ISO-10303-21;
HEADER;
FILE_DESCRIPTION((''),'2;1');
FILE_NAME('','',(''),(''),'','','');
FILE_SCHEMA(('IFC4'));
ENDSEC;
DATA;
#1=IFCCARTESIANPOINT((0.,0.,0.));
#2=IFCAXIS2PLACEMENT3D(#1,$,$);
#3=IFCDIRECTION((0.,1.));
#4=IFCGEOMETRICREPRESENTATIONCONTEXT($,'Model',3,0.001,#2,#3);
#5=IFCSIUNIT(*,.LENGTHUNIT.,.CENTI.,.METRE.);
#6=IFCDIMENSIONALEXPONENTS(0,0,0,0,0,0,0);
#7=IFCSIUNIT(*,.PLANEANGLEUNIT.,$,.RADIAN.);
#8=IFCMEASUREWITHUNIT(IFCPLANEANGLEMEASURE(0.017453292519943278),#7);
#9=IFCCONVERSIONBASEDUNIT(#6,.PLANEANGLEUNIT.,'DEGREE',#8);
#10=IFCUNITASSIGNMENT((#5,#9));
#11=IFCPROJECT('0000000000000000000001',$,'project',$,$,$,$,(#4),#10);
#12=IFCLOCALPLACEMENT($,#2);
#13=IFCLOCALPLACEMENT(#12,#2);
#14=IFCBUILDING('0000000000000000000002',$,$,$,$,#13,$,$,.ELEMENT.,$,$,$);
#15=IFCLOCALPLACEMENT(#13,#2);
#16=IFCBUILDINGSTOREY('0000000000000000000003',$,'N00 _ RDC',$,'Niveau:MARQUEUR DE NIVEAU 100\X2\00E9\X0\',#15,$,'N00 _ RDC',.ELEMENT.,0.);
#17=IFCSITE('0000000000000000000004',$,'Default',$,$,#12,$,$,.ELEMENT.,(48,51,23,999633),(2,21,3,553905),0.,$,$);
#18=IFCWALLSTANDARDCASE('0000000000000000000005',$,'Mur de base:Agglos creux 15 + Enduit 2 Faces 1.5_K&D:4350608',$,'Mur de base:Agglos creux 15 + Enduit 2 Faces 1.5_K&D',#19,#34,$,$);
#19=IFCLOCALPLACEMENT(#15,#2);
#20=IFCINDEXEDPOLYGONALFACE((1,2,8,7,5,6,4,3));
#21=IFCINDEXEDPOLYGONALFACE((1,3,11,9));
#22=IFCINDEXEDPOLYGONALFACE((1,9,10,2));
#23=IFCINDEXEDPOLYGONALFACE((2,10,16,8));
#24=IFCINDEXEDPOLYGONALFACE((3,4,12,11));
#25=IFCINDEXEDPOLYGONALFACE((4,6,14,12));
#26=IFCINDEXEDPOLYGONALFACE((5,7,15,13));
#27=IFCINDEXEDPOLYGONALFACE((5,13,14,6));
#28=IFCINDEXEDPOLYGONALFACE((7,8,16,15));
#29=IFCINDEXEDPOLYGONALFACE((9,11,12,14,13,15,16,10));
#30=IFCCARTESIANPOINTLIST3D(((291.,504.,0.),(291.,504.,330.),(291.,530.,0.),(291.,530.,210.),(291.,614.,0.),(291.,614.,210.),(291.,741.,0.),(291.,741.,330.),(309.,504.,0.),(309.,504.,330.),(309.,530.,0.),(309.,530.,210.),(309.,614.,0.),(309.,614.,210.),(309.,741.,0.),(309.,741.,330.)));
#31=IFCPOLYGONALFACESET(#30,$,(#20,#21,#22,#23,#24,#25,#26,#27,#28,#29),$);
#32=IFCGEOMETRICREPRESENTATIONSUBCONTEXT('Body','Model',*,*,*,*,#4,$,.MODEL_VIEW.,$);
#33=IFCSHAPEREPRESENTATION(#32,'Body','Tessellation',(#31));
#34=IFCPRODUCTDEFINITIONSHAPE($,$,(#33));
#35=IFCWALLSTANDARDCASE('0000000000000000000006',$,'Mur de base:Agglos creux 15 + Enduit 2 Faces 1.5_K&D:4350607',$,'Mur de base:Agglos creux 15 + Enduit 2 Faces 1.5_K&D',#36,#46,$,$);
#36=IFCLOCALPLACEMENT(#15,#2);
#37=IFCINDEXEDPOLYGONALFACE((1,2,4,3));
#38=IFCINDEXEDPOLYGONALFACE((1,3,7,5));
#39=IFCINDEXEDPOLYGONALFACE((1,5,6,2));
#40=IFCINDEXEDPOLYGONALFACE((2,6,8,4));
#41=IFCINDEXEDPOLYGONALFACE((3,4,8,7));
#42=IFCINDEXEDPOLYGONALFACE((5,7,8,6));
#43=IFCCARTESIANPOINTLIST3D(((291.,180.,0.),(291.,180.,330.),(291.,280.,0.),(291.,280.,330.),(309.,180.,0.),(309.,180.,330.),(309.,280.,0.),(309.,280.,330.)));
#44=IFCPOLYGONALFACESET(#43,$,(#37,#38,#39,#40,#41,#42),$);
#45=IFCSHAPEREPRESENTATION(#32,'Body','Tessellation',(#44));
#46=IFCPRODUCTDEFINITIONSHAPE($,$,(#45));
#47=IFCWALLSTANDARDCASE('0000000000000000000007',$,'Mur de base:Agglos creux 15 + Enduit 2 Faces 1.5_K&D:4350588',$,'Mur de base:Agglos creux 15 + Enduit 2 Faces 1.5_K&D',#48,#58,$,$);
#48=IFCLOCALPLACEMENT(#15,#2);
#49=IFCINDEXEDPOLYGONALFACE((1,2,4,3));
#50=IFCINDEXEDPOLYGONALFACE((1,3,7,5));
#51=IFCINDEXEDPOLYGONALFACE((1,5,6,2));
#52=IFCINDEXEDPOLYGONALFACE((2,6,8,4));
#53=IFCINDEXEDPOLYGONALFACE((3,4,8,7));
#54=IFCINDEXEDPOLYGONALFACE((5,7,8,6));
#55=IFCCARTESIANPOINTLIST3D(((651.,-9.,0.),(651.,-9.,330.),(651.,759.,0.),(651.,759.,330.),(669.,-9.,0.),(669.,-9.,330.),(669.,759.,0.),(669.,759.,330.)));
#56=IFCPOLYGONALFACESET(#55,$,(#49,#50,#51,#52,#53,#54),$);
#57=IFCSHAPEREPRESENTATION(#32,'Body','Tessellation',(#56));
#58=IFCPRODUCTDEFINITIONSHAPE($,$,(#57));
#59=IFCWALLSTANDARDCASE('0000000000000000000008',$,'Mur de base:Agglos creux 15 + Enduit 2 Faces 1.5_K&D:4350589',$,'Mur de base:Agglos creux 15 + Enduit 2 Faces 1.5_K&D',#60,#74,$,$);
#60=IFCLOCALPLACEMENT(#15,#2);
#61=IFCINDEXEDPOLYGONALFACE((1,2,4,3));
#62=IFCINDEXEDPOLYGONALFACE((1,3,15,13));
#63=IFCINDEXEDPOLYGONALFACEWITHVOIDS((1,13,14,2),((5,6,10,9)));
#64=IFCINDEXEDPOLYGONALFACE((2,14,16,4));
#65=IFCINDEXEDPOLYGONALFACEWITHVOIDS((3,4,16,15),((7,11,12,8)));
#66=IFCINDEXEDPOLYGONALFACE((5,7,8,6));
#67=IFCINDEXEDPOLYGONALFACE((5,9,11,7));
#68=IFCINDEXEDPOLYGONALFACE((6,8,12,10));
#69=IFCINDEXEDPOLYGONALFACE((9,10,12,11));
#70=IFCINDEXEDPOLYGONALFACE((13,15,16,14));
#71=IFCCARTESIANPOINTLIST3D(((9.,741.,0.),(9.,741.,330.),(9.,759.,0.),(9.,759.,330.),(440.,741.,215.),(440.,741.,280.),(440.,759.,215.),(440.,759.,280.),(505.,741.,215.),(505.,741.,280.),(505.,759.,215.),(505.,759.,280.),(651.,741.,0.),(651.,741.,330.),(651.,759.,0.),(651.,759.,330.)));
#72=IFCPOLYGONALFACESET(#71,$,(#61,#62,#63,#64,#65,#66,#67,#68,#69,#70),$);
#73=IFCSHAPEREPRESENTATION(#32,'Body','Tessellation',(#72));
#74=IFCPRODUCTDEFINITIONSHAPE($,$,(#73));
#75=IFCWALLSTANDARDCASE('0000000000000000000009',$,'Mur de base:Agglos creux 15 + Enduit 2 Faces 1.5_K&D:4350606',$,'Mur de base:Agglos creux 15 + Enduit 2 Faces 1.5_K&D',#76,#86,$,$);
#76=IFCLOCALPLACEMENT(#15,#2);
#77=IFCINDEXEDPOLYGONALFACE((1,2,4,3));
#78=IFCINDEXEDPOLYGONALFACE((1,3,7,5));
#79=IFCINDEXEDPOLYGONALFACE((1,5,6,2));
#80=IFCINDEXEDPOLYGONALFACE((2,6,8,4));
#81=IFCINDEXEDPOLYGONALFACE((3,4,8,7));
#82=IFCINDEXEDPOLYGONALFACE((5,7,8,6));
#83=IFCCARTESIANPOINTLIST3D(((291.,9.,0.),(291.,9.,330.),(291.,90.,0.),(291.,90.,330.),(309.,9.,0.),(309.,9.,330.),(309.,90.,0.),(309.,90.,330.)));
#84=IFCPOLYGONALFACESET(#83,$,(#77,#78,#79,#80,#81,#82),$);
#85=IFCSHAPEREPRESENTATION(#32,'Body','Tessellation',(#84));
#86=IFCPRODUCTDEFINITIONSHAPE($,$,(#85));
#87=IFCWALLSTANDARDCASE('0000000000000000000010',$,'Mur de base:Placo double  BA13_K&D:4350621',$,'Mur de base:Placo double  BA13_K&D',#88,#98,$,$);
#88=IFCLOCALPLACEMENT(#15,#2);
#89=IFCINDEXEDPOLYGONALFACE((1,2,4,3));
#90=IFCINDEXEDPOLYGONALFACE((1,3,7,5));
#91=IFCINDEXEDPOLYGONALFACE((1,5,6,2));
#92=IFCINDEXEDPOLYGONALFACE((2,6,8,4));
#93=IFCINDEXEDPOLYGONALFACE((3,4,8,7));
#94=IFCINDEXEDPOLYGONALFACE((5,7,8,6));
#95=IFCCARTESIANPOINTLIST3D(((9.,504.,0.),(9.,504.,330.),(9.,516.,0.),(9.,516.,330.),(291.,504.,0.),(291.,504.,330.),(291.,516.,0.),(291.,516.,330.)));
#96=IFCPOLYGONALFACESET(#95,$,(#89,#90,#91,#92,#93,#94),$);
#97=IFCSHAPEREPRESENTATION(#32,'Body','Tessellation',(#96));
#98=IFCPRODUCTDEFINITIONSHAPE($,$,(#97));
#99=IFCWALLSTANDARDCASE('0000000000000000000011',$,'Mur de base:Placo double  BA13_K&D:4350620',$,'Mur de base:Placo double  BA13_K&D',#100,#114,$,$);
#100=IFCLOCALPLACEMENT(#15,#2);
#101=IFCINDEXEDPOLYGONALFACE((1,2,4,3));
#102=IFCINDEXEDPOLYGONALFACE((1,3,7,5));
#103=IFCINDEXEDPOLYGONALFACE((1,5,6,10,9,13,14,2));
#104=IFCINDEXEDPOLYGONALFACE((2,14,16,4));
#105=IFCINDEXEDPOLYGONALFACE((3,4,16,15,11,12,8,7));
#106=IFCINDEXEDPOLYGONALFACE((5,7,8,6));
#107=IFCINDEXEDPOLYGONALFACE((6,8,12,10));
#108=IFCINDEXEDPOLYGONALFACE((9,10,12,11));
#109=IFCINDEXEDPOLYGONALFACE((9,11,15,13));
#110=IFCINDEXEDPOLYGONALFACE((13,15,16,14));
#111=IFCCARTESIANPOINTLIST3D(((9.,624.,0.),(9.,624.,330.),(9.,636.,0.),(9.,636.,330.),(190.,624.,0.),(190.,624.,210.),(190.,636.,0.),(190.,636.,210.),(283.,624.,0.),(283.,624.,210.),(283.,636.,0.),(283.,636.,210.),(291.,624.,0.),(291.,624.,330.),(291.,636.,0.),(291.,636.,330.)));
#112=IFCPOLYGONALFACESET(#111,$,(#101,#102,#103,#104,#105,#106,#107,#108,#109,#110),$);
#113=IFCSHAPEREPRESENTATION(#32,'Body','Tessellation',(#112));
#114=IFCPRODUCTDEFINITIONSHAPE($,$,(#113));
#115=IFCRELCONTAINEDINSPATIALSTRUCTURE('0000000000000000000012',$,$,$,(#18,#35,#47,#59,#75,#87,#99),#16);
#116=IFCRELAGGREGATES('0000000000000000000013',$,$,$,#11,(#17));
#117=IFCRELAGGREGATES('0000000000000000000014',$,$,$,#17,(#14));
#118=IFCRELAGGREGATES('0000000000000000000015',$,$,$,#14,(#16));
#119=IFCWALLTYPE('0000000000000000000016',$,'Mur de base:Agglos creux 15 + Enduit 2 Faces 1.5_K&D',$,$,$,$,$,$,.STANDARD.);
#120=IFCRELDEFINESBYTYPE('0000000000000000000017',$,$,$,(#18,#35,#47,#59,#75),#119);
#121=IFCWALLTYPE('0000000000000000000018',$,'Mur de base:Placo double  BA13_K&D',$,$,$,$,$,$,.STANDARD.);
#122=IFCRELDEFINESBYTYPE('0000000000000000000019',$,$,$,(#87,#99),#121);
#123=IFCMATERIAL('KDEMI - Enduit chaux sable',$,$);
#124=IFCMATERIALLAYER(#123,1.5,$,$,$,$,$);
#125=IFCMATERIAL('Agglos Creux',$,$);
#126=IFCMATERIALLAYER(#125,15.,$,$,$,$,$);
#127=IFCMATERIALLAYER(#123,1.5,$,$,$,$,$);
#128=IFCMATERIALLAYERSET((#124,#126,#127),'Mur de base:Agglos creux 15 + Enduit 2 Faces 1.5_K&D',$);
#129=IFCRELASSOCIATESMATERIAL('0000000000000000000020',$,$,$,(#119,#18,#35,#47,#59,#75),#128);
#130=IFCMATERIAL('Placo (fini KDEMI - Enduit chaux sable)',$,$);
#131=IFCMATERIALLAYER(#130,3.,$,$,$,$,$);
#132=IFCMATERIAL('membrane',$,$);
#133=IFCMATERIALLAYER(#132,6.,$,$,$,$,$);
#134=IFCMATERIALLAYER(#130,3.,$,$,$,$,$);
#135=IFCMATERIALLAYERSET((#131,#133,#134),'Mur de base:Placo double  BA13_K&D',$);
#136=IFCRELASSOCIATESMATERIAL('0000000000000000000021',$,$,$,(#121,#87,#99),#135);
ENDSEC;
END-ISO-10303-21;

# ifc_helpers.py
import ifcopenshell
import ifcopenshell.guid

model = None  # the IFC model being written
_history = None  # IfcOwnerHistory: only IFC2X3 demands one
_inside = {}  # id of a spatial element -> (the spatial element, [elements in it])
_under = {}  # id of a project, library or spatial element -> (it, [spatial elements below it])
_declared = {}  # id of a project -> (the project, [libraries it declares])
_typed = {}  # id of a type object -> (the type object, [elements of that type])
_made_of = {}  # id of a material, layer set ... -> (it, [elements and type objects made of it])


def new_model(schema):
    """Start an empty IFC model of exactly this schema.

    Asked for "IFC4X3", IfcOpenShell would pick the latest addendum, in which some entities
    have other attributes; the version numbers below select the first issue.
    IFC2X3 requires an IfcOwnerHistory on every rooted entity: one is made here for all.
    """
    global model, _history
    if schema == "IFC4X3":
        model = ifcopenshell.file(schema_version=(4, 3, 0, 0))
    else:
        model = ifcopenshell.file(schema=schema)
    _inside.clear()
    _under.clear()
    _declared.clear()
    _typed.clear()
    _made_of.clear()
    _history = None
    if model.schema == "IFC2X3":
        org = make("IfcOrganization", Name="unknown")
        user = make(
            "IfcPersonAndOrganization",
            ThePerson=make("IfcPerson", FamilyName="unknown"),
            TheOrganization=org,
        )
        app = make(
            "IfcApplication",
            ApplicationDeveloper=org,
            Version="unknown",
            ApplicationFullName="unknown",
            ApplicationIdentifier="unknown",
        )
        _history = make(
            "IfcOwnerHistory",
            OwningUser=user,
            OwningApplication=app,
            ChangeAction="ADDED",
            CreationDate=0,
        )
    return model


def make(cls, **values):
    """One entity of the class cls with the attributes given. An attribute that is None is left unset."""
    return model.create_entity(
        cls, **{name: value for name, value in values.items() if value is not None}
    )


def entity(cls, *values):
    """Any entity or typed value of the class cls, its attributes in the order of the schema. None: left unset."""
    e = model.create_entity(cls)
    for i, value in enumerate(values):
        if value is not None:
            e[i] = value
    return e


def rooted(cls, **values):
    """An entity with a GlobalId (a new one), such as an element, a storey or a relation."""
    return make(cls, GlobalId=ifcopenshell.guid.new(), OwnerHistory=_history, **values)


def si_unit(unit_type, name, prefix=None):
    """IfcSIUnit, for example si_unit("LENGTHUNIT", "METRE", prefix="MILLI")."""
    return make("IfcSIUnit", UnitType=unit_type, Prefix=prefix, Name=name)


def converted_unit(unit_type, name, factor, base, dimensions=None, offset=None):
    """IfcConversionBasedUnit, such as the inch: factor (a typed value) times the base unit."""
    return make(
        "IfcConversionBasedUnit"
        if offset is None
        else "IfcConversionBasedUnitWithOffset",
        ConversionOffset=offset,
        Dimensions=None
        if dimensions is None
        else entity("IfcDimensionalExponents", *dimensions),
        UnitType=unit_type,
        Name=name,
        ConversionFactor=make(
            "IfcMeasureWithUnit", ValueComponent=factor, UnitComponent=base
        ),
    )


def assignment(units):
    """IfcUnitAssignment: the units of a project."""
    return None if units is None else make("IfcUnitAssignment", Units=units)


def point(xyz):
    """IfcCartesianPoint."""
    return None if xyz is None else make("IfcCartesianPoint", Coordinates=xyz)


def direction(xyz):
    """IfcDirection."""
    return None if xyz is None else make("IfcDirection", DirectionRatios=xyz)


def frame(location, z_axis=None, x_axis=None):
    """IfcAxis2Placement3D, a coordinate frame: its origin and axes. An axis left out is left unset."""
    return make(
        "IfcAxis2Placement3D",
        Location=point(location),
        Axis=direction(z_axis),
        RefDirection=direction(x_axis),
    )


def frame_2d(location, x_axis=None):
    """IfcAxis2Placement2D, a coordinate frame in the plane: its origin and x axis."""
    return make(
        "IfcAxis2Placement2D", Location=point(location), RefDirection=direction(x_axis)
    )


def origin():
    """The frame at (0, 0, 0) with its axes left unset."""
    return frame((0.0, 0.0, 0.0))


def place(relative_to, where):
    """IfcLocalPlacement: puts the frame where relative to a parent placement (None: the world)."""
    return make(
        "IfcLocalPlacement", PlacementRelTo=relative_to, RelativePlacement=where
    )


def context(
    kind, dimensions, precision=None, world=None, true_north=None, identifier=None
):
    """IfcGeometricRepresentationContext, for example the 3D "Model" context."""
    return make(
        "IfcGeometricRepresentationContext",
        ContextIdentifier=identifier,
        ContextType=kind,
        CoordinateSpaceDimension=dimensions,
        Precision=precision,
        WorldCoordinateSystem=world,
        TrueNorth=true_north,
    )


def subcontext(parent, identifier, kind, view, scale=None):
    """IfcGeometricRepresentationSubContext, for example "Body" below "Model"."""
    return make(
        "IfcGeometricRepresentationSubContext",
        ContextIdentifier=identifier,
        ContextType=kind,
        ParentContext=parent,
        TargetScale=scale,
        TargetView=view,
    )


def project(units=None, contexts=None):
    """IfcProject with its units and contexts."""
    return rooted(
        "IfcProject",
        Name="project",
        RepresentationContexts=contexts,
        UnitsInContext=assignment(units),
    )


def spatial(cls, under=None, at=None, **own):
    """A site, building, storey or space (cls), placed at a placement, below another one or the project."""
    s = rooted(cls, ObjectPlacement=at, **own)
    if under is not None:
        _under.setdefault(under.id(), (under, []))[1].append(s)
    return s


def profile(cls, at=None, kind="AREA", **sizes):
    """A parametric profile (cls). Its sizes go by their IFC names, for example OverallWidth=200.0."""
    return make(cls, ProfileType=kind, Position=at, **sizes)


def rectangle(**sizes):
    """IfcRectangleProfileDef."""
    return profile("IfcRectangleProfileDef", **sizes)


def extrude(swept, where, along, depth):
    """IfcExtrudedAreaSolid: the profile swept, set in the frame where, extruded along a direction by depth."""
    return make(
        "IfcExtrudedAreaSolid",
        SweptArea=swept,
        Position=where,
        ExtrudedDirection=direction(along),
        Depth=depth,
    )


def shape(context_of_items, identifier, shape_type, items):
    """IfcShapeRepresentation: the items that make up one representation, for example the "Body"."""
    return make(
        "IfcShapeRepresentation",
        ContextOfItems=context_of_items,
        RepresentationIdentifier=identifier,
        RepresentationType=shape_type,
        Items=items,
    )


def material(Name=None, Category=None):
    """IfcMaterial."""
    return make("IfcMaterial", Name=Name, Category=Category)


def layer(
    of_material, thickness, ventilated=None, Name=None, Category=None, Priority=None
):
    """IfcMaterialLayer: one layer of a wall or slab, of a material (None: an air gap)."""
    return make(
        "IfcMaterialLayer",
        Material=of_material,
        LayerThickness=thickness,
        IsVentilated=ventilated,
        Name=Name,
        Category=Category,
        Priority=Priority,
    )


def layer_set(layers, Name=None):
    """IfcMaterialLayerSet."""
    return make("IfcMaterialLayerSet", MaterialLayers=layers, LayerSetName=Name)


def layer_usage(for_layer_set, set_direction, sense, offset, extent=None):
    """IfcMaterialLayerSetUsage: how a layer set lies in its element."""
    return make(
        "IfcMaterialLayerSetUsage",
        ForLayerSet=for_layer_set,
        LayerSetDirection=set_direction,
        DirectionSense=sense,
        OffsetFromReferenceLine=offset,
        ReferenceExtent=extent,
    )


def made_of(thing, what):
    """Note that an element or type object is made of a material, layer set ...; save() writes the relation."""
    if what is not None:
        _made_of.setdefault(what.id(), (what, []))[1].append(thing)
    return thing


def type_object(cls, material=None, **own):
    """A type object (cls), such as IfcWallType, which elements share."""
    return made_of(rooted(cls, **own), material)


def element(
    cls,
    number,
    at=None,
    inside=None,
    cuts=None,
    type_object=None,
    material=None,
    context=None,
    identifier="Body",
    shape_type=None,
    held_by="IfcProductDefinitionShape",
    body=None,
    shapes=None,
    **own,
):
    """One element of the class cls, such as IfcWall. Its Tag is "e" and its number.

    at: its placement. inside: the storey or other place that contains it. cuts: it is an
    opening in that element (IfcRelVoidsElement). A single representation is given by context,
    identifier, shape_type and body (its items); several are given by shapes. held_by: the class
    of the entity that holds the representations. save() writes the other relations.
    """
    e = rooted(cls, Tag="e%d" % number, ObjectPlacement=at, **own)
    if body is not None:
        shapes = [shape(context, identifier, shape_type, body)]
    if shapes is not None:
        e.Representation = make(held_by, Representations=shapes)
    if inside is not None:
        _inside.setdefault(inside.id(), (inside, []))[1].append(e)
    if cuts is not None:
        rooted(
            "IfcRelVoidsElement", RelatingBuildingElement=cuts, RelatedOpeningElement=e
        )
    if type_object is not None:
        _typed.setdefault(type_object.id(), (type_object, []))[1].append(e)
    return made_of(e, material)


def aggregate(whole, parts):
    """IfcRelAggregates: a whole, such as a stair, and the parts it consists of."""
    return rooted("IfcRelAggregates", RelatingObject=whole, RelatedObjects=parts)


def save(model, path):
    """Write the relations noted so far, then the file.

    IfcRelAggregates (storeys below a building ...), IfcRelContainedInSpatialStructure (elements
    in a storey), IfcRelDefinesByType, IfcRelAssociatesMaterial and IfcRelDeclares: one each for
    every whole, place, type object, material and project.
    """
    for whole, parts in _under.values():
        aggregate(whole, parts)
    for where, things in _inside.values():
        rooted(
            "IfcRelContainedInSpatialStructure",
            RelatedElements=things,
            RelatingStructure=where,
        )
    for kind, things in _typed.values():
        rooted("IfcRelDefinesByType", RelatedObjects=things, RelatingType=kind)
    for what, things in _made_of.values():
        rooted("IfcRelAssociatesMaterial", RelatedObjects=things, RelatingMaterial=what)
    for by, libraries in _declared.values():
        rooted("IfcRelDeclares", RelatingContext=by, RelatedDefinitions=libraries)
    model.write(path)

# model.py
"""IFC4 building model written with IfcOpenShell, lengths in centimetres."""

from ifc_helpers import new_model, entity, si_unit, converted_unit, direction, frame, frame_2d, origin, place, context, subcontext, project, spatial, rectangle, extrude, material, layer, layer_set, layer_usage, type_object, element, save


model = new_model("IFC4")

# Units and contexts
model_context = context("Model", 3, precision=0.001, world=origin(), true_north=direction((0.0, 1.0)))
body_context = subcontext(model_context, "Body", "Model", "MODEL_VIEW")
ifc_project = project(units=[si_unit("LENGTHUNIT", "METRE", prefix="CENTI"), converted_unit("PLANEANGLEUNIT", "DEGREE", entity("IfcPlaneAngleMeasure", 0.017453292519943278), si_unit("PLANEANGLEUNIT", "RADIAN"), dimensions=[0, 0, 0, 0, 0, 0, 0])], contexts=[model_context])

# Site, building, storey
site_placement = place(None, origin())
site = spatial("IfcSite", under=ifc_project, at=site_placement, Name="Default", CompositionType="ELEMENT", RefLatitude=(48, 51, 23, 999633), RefLongitude=(2, 21, 3, 553905), RefElevation=0.0)
building_placement = place(site_placement, origin())
building = spatial("IfcBuilding", under=site, at=building_placement, CompositionType="ELEMENT")
storey_placement = place(building_placement, origin())
storey = spatial("IfcBuildingStorey", under=building, at=storey_placement, Name="N00 _ RDC", ObjectType="Niveau:MARQUEUR DE NIVEAU 100é", LongName="N00 _ RDC", CompositionType="ELEMENT", Elevation=0.0)

# Wall, opening
ifc_material_1 = material(Name="KDEMI - Enduit chaux sable")
ifc_layer_1 = layer(ifc_material_1, 1.5)
ifc_material_2 = material(Name="Agglos Creux")
ifc_layer_2 = layer(ifc_material_2, 15.0)
ifc_layer_3 = layer(ifc_material_1, 1.5)
ifc_layer_set_1 = layer_set([ifc_layer_1, ifc_layer_2, ifc_layer_3], Name="Mur de base:Agglos creux 15 + Enduit 2 Faces 1.5_K&D")
ifc_layer_usage_1 = layer_usage(ifc_layer_set_1, "AXIS2", "POSITIVE", -9.0)
wall_type_1 = type_object("IfcWallType", Name="Mur de base:Agglos creux 15 + Enduit 2 Faces 1.5_K&D", PredefinedType="STANDARD", material=ifc_layer_set_1)
wall_1_placement = place(storey_placement, frame((300.0, 504.0, 0.0), z_axis=(0.0, 0.0, 1.0), x_axis=(0.0, 1.0, 0.0)))
wall_1 = element("IfcWallStandardCase", 1, at=wall_1_placement, inside=storey, type_object=wall_type_1, material=ifc_layer_usage_1, Name="Mur de base:Agglos creux 15 + Enduit 2 Faces 1.5_K&D:4350608", ObjectType="Mur de base:Agglos creux 15 + Enduit 2 Faces 1.5_K&D", context=body_context, shape_type="SweptSolid", body=[
    extrude(rectangle(XDim=237.0, YDim=18.0, at=frame_2d((118.5, 0.0), x_axis=(1.0, 0.0))), origin(), (0.0, 0.0, 1.0), 330.0),
])
opening_1_placement = place(wall_1_placement, frame((-504.0, 300.0, 0.0), z_axis=(0.0, 0.0, 1.0), x_axis=(0.0, -1.0, 0.0)))
element("IfcOpeningElement", 2, at=opening_1_placement, inside=storey, cuts=wall_1, context=body_context, shape_type="SweptSolid", body=[
    extrude(rectangle(XDim=22.0, YDim=84.0, at=frame_2d((300.0, 572.0))), origin(), (0.0, 0.0, 1.0), 210.0),
])

# Walls
ifc_layer_usage_2 = layer_usage(ifc_layer_set_1, "AXIS2", "NEGATIVE", 9.0)
wall_2_placement = place(storey_placement, frame((300.0, 180.0, 0.0), z_axis=(0.0, 0.0, 1.0), x_axis=(0.0, 1.0, 0.0)))
element("IfcWallStandardCase", 3, at=wall_2_placement, inside=storey, type_object=wall_type_1, material=ifc_layer_usage_2, Name="Mur de base:Agglos creux 15 + Enduit 2 Faces 1.5_K&D:4350607", ObjectType="Mur de base:Agglos creux 15 + Enduit 2 Faces 1.5_K&D", context=body_context, shape_type="SweptSolid", body=[
    extrude(rectangle(XDim=100.0, YDim=18.0, at=frame_2d((50.0, 0.0), x_axis=(-1.0, 0.0))), origin(), (0.0, 0.0, 1.0), 330.0),
])
ifc_layer_usage_3 = layer_usage(ifc_layer_set_1, "AXIS2", "NEGATIVE", 9.0)
wall_3_placement = place(storey_placement, frame((660.0, -9.0, 0.0), z_axis=(0.0, 0.0, 1.0), x_axis=(0.0, 1.0, 0.0)))
element("IfcWallStandardCase", 4, at=wall_3_placement, inside=storey, type_object=wall_type_1, material=ifc_layer_usage_3, Name="Mur de base:Agglos creux 15 + Enduit 2 Faces 1.5_K&D:4350588", ObjectType="Mur de base:Agglos creux 15 + Enduit 2 Faces 1.5_K&D", context=body_context, shape_type="SweptSolid", body=[
    extrude(rectangle(XDim=768.0, YDim=18.0, at=frame_2d((384.0, 0.0), x_axis=(-1.0, 0.0))), origin(), (0.0, 0.0, 1.0), 330.0),
])

# Wall, opening
ifc_layer_usage_4 = layer_usage(ifc_layer_set_1, "AXIS2", "NEGATIVE", 9.0)
wall_4_placement = place(storey_placement, frame((9.0, 750.0, 0.0)))
wall_4 = element("IfcWallStandardCase", 5, at=wall_4_placement, inside=storey, type_object=wall_type_1, material=ifc_layer_usage_4, Name="Mur de base:Agglos creux 15 + Enduit 2 Faces 1.5_K&D:4350589", ObjectType="Mur de base:Agglos creux 15 + Enduit 2 Faces 1.5_K&D", context=body_context, shape_type="SweptSolid", body=[
    extrude(rectangle(XDim=642.0, YDim=18.0, at=frame_2d((321.0, 0.0), x_axis=(-1.0, 0.0))), origin(), (0.0, 0.0, 1.0), 330.0),
])
opening_2_placement = place(wall_4_placement, origin())
element("IfcOpeningElement", 6, at=opening_2_placement, cuts=wall_4, ObjectType="Opening", context=body_context, shape_type="SweptSolid", body=[
    extrude(rectangle(XDim=65.0, YDim=65.0, at=frame_2d((0.0, 0.0), x_axis=(1.0, 0.0))), frame((463.5, -9.0, 247.5), z_axis=(0.0, 1.0, 0.0), x_axis=(0.0, 0.0, -1.0)), (0.0, 0.0, 1.0), 18.0),
])

# Walls
ifc_layer_usage_5 = layer_usage(ifc_layer_set_1, "AXIS2", "NEGATIVE", 9.0)
wall_5_placement = place(storey_placement, frame((300.0, 9.0, 0.0), z_axis=(0.0, 0.0, 1.0), x_axis=(0.0, 1.0, 0.0)))
element("IfcWallStandardCase", 7, at=wall_5_placement, inside=storey, type_object=wall_type_1, material=ifc_layer_usage_5, Name="Mur de base:Agglos creux 15 + Enduit 2 Faces 1.5_K&D:4350606", ObjectType="Mur de base:Agglos creux 15 + Enduit 2 Faces 1.5_K&D", context=body_context, shape_type="SweptSolid", body=[
    extrude(rectangle(XDim=81.0, YDim=18.0, at=frame_2d((40.5, 0.0), x_axis=(-1.0, 0.0))), origin(), (0.0, 0.0, 1.0), 330.0),
])
ifc_material_3 = material(Name="Placo (fini KDEMI - Enduit chaux sable)")
ifc_layer_4 = layer(ifc_material_3, 3.0)
ifc_material_4 = material(Name="membrane")
ifc_layer_5 = layer(ifc_material_4, 6.0)
ifc_layer_6 = layer(ifc_material_3, 3.0)
ifc_layer_set_2 = layer_set([ifc_layer_4, ifc_layer_5, ifc_layer_6], Name="Mur de base:Placo double  BA13_K&D")
ifc_layer_usage_6 = layer_usage(ifc_layer_set_2, "AXIS2", "POSITIVE", -6.0)
wall_type_2 = type_object("IfcWallType", Name="Mur de base:Placo double  BA13_K&D", PredefinedType="STANDARD", material=ifc_layer_set_2)
wall_6_placement = place(storey_placement, frame((9.0, 510.0, 0.0)))
element("IfcWallStandardCase", 8, at=wall_6_placement, inside=storey, type_object=wall_type_2, material=ifc_layer_usage_6, Name="Mur de base:Placo double  BA13_K&D:4350621", ObjectType="Mur de base:Placo double  BA13_K&D", context=body_context, shape_type="SweptSolid", body=[
    extrude(rectangle(XDim=282.0, YDim=12.0, at=frame_2d((141.0, 0.0), x_axis=(-1.0, 0.0))), origin(), (0.0, 0.0, 1.0), 330.0),
])

# Wall, opening
ifc_layer_usage_7 = layer_usage(ifc_layer_set_2, "AXIS2", "NEGATIVE", 6.0)
wall_7_placement = place(storey_placement, frame((9.0, 630.0, 0.0)))
wall_7 = element("IfcWallStandardCase", 9, at=wall_7_placement, inside=storey, type_object=wall_type_2, material=ifc_layer_usage_7, Name="Mur de base:Placo double  BA13_K&D:4350620", ObjectType="Mur de base:Placo double  BA13_K&D", context=body_context, shape_type="SweptSolid", body=[
    extrude(rectangle(XDim=282.0, YDim=12.0, at=frame_2d((141.0, 0.0), x_axis=(-1.0, 0.0))), origin(), (0.0, 0.0, 1.0), 330.0),
])
opening_3_placement = place(wall_7_placement, frame((-9.0, -630.0, 0.0), z_axis=(0.0, 0.0, 1.0), x_axis=(1.0, 0.0, 0.0)))
element("IfcOpeningElement", 10, at=opening_3_placement, inside=storey, cuts=wall_7, context=body_context, shape_type="SweptSolid", body=[
    extrude(rectangle(XDim=93.0, YDim=16.0, at=frame_2d((236.5, 630.0))), origin(), (0.0, 0.0, 1.0), 210.0),
])

save(model, "model.ifc")
